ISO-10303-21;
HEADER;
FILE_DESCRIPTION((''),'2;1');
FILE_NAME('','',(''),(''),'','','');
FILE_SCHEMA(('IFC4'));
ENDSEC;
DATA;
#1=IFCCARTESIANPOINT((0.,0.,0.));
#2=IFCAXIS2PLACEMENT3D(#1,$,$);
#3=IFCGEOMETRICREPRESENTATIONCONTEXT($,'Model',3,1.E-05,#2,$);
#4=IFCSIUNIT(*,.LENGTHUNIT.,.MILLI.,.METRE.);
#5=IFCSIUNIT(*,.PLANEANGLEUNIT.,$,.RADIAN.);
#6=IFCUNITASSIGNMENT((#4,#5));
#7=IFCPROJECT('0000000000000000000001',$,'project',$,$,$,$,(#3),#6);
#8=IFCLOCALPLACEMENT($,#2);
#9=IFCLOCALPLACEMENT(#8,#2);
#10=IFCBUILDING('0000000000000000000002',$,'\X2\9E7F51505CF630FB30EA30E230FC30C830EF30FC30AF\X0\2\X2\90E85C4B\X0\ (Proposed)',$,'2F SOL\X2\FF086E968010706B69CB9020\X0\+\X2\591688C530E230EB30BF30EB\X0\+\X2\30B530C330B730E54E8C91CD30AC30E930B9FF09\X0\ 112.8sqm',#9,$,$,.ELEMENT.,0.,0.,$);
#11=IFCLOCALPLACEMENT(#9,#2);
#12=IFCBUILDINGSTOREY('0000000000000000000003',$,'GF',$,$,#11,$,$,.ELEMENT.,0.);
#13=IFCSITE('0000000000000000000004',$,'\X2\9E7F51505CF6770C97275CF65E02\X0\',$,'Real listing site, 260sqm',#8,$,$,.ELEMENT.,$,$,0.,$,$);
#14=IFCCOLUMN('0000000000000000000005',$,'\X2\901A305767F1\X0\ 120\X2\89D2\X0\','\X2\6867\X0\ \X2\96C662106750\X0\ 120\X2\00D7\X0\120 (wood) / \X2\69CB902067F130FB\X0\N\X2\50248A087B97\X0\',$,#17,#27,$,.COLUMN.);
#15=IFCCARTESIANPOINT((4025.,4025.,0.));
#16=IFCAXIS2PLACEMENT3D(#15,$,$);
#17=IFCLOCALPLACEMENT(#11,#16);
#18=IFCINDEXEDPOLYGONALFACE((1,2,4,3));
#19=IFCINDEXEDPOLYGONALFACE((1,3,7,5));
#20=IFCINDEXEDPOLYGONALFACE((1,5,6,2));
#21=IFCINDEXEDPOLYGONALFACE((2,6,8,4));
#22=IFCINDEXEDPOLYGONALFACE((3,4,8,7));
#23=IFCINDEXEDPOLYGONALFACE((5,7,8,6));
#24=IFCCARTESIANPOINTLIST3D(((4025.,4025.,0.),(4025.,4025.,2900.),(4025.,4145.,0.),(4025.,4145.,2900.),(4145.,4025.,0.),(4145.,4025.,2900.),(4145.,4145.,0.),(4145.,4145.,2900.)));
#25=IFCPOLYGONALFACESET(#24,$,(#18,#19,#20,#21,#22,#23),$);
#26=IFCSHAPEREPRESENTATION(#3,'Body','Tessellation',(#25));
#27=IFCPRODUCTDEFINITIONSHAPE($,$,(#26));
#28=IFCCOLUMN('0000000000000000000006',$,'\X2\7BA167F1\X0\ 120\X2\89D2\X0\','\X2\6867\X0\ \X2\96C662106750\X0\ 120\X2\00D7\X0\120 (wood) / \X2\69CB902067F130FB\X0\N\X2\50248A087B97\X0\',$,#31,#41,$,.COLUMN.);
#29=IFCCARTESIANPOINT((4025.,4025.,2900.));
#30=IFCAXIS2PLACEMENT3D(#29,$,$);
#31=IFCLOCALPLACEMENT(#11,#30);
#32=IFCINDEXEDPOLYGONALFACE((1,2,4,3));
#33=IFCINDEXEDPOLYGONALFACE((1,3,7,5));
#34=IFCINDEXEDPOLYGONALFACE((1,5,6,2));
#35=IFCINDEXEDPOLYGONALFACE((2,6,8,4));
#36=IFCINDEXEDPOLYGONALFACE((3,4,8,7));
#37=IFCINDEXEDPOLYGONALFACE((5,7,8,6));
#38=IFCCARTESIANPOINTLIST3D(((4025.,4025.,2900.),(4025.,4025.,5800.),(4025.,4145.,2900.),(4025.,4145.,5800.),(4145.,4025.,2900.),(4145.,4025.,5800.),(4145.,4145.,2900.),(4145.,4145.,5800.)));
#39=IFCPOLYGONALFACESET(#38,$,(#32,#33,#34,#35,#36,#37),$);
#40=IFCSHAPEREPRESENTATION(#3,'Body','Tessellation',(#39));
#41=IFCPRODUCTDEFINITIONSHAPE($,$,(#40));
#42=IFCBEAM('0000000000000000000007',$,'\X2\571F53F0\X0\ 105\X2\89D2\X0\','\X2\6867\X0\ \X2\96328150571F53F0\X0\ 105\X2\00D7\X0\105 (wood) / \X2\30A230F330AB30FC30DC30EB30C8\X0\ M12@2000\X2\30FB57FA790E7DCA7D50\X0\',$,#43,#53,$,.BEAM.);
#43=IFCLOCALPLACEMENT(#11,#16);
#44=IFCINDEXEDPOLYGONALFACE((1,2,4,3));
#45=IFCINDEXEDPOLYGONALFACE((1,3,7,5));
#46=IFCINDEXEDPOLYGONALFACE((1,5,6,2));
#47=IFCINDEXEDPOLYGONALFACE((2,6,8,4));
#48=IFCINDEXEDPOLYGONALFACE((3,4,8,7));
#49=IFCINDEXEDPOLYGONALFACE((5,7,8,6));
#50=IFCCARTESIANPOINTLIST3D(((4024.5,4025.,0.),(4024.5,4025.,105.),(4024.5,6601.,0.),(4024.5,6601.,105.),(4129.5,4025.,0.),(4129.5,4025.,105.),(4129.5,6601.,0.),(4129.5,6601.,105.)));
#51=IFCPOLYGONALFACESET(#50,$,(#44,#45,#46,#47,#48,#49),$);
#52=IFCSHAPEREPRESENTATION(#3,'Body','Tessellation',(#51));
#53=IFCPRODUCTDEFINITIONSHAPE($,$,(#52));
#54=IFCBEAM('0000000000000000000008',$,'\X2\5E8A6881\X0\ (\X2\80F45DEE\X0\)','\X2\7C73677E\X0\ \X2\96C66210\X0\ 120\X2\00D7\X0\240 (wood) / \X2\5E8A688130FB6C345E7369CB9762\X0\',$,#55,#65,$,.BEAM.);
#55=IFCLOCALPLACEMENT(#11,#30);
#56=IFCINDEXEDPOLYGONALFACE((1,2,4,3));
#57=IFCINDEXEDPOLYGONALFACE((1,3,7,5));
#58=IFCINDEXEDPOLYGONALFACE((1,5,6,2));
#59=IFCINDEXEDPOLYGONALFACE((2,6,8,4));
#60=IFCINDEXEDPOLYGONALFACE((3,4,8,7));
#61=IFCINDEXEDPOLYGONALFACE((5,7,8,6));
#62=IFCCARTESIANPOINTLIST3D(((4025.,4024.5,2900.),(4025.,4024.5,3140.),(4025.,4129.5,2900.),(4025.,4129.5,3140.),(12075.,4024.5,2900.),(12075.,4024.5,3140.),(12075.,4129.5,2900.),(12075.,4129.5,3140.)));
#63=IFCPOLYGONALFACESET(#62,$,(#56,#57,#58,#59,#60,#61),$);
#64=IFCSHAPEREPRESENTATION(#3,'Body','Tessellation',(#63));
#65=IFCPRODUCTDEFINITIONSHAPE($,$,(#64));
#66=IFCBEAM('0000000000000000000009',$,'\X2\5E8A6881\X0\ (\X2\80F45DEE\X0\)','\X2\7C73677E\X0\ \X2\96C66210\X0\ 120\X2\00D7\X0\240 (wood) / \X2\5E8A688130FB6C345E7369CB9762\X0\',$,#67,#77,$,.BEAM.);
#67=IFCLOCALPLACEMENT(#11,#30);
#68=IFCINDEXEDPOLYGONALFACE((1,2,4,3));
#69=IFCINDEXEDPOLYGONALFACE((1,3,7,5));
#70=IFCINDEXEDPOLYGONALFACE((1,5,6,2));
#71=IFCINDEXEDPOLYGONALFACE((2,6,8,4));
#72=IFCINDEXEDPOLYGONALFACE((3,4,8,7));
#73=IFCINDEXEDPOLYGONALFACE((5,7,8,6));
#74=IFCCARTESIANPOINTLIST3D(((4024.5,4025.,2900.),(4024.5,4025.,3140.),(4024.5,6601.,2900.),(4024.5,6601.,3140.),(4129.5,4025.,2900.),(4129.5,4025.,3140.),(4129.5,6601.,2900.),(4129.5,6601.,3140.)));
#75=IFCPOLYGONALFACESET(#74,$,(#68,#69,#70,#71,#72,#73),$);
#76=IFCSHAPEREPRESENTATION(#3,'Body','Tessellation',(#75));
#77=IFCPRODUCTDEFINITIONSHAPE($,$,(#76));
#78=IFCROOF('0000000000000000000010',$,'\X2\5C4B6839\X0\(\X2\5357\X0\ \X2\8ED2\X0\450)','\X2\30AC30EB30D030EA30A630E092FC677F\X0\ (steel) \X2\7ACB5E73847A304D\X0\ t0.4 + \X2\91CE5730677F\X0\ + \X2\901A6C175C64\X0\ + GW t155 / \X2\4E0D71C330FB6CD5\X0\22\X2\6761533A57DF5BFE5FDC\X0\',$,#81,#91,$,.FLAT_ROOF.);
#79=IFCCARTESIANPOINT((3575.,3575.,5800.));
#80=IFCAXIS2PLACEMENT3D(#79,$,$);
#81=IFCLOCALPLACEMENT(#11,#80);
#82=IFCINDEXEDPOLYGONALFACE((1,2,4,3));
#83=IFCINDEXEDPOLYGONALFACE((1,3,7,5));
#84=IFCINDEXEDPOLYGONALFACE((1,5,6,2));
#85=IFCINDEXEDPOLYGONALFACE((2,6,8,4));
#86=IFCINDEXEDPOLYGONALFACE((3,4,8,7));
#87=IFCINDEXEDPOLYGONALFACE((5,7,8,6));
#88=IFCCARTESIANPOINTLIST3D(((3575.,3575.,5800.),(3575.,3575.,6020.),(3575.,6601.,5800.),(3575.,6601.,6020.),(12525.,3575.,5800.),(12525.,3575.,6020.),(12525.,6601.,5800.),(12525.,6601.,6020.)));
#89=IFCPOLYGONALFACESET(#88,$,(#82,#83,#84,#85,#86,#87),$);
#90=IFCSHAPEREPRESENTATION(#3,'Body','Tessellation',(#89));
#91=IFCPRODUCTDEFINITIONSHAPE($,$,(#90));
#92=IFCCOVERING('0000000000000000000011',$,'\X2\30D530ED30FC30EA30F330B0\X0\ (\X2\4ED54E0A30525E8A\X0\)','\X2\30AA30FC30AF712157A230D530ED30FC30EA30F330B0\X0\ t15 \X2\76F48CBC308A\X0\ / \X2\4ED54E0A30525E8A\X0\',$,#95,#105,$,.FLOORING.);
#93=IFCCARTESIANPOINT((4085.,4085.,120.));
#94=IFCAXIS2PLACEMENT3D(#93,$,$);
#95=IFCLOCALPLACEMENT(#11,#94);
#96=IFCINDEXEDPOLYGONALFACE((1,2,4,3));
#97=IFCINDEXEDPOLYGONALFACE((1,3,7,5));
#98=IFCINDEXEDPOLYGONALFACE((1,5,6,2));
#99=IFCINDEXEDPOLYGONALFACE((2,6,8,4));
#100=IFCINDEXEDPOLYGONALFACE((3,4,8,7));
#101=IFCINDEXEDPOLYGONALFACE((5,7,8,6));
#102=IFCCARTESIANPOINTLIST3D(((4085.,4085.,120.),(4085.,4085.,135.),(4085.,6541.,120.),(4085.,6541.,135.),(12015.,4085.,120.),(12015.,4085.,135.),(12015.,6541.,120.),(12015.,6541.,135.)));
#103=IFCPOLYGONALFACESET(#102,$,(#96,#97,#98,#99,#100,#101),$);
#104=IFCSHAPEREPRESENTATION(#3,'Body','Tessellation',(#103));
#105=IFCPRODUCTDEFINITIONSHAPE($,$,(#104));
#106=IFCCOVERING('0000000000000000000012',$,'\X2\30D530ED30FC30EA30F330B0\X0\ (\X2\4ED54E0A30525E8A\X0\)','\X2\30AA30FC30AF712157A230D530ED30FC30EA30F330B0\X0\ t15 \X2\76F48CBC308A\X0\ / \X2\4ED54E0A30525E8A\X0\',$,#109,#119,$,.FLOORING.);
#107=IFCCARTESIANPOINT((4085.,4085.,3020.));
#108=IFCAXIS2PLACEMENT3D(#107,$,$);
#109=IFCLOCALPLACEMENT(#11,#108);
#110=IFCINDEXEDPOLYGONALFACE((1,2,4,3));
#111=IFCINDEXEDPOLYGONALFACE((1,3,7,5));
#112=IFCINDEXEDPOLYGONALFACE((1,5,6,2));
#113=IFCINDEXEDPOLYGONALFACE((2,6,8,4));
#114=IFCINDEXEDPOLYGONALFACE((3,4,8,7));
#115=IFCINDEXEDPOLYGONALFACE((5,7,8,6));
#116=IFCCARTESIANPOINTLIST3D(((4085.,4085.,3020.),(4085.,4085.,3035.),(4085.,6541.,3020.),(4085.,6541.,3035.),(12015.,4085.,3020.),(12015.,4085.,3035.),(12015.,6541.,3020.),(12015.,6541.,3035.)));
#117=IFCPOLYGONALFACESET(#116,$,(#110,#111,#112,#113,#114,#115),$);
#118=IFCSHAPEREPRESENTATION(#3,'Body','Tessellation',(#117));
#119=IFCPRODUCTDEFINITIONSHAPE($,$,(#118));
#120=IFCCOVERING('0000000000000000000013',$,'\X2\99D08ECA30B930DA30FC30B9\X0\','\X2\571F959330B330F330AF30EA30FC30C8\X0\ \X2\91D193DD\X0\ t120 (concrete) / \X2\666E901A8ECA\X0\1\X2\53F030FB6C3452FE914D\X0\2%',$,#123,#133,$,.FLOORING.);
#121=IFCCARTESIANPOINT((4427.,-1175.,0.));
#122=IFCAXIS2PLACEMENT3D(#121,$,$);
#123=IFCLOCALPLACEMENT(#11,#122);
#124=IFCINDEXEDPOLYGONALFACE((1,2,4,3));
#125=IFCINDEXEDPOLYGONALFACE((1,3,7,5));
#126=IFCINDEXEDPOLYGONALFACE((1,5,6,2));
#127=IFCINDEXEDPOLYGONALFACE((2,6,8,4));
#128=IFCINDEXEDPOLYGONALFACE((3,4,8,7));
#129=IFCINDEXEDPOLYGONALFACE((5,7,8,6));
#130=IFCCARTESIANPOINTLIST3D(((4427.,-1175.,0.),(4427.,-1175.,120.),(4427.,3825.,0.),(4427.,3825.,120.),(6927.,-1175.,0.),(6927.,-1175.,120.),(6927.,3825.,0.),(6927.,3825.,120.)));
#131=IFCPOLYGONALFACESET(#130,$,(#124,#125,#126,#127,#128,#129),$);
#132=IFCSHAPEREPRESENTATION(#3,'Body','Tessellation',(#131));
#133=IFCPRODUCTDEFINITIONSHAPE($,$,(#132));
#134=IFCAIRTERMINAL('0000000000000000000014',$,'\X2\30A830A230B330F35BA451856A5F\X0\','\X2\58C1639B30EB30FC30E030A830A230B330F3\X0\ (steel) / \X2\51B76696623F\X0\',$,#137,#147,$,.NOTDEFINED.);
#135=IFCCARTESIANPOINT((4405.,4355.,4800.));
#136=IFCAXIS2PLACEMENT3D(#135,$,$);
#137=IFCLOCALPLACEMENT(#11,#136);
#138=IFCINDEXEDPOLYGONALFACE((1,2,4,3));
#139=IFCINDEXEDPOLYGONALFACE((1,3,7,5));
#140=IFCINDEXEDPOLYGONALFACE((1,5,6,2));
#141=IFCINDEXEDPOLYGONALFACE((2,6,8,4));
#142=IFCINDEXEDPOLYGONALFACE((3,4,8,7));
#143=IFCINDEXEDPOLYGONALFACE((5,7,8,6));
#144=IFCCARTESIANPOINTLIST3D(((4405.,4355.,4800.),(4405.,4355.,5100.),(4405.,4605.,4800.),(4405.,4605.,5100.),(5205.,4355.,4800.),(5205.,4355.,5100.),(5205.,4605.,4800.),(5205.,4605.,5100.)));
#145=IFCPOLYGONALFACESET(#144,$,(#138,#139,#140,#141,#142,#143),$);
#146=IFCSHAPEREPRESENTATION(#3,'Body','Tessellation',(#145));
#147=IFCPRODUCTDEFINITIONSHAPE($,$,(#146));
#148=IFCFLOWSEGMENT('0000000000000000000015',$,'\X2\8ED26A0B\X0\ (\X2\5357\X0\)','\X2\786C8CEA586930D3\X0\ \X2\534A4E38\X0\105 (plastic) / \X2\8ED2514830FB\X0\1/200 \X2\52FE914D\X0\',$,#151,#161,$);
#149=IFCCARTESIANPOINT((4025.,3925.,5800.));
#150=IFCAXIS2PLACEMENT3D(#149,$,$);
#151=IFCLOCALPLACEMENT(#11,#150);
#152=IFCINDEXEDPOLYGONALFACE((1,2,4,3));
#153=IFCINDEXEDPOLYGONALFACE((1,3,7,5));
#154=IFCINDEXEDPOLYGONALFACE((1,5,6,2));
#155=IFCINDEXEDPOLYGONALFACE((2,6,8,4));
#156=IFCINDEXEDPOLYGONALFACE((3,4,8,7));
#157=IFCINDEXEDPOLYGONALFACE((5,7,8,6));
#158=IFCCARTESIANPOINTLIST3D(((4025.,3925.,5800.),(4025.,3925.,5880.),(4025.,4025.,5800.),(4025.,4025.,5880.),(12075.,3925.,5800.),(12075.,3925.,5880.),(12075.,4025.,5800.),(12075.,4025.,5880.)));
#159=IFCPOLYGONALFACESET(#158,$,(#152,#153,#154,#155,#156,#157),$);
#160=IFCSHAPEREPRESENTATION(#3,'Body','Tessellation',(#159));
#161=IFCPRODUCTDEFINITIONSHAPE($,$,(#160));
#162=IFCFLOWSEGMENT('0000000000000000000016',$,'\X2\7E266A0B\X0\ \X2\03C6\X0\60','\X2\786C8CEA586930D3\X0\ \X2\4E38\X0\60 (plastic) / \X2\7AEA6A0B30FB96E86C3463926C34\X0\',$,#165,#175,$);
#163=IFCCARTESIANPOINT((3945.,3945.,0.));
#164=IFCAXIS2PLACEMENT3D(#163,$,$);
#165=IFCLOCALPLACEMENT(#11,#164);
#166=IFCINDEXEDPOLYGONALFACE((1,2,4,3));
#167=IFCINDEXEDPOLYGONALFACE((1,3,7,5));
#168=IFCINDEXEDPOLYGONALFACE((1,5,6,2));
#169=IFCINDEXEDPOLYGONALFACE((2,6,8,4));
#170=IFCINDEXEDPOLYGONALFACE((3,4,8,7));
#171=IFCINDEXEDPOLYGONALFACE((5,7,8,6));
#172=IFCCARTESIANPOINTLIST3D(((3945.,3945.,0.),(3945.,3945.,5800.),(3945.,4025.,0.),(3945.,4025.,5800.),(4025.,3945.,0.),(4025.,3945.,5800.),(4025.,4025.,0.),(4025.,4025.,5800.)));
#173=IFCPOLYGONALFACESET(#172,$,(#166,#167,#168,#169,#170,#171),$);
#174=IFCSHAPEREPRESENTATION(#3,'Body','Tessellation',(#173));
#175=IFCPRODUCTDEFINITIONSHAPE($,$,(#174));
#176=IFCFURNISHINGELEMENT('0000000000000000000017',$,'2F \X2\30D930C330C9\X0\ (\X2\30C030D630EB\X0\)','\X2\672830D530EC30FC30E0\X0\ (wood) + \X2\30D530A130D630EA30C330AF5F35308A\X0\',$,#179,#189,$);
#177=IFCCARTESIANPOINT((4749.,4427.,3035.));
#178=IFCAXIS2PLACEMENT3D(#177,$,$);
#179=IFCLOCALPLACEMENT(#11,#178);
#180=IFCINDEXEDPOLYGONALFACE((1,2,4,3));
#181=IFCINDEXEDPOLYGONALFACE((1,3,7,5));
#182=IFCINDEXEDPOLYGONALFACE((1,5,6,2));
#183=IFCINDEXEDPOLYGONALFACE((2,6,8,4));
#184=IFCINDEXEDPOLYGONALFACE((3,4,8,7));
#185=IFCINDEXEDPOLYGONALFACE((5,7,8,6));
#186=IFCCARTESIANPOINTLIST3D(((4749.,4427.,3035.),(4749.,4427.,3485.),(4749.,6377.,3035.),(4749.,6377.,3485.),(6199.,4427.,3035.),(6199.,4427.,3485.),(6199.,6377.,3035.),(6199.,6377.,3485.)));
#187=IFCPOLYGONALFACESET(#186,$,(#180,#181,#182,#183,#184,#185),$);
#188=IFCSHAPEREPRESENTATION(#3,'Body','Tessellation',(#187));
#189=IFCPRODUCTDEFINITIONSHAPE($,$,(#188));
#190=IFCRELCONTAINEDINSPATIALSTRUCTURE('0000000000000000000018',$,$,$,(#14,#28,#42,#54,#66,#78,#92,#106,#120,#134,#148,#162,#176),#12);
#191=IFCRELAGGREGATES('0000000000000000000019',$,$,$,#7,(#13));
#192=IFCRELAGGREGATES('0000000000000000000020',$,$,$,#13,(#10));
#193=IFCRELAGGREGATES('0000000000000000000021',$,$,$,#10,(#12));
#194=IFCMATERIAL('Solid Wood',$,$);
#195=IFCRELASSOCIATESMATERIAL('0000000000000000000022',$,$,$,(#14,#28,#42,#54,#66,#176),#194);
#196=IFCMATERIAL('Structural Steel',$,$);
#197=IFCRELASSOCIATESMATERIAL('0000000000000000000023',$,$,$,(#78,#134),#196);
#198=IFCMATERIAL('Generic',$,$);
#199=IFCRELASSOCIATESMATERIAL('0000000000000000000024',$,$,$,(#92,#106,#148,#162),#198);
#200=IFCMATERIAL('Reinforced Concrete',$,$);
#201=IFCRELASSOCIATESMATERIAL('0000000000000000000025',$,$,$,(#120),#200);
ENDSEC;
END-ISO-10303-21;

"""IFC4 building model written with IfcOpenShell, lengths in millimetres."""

from ifc_helpers import new_model, si_unit, frame, frame_2d, origin, place, context, project, spatial, rectangle, extrude, material, element, save


model = new_model("IFC4")

# Units and contexts
model_context = context("Model", 3, precision=1e-05, world=origin())
ifc_project = project(units=[si_unit("LENGTHUNIT", "METRE", prefix="MILLI"), si_unit("PLANEANGLEUNIT", "RADIAN")], contexts=[model_context])

# Site, building, storey
site_placement = place(None, origin())
site = spatial("IfcSite", under=ifc_project, at=site_placement, Name="鹿児島県霧島市", ObjectType="Real listing site, 260sqm", CompositionType="ELEMENT", RefElevation=0.0)
building_placement = place(site_placement, origin())
building = spatial("IfcBuilding", under=site, at=building_placement, Name="鹿児島・リモートワーク2部屋 (Proposed)", ObjectType="2F SOL（準耐火構造+外装モルタル+サッシュ二重ガラス） 112.8sqm", CompositionType="ELEMENT", ElevationOfRefHeight=0.0, ElevationOfTerrain=0.0)
storey_placement = place(building_placement, origin())
storey = spatial("IfcBuildingStorey", under=building, at=storey_placement, Name="GF", CompositionType="ELEMENT", Elevation=0.0)

# Columns
ifc_material_1 = material(Name="Solid Wood")
column_1_placement = place(storey_placement, frame((4025.0, 4025.0, 0.0)))
element("IfcColumn", 1, at=column_1_placement, inside=storey, material=ifc_material_1, Name="通し柱 120角", Description="桧 集成材 120×120 (wood) / 構造柱・N値計算", PredefinedType="COLUMN", context=model_context, shape_type="SweptSolid", body=[
    extrude(rectangle(XDim=120.0, YDim=120.0, at=frame_2d((60.0, 60.0))), frame((4025.0, 4025.0, 0.0)), (0.0, 0.0, 1.0), 2900.0),
])
column_2_placement = place(storey_placement, frame((4025.0, 4025.0, 2900.0)))
element("IfcColumn", 2, at=column_2_placement, inside=storey, material=ifc_material_1, Name="管柱 120角", Description="桧 集成材 120×120 (wood) / 構造柱・N値計算", PredefinedType="COLUMN", context=model_context, shape_type="SweptSolid", body=[
    extrude(rectangle(XDim=120.0, YDim=120.0, at=frame_2d((60.0, 60.0))), frame((4025.0, 4025.0, 2900.0)), (0.0, 0.0, 1.0), 2900.0),
])

# Beams
beam_1_placement = place(storey_placement, frame((4025.0, 4025.0, 0.0)))
element("IfcBeam", 3, at=beam_1_placement, inside=storey, material=ifc_material_1, Name="土台 105角", Description="桧 防腐土台 105×105 (wood) / アンカーボルト M12@2000・基礎緊結", PredefinedType="BEAM", context=model_context, shape_type="SweptSolid", body=[
    extrude(rectangle(XDim=105.0, YDim=2576.0, at=frame_2d((52.0, 1288.0))), frame((4025.0, 4025.0, 0.0)), (0.0, 0.0, 1.0), 105.0),
])
beam_2_placement = place(storey_placement, frame((4025.0, 4025.0, 2900.0)))
element("IfcBeam", 4, at=beam_2_placement, inside=storey, material=ifc_material_1, Name="床梁 (胴差)", Description="米松 集成 120×240 (wood) / 床梁・水平構面", PredefinedType="BEAM", context=model_context, shape_type="SweptSolid", body=[
    extrude(rectangle(XDim=8050.0, YDim=105.0, at=frame_2d((4025.0, 52.0))), frame((4025.0, 4025.0, 2900.0)), (0.0, 0.0, 1.0), 240.0),
])
beam_3_placement = place(storey_placement, frame((4025.0, 4025.0, 2900.0)))
element("IfcBeam", 5, at=beam_3_placement, inside=storey, material=ifc_material_1, Name="床梁 (胴差)", Description="米松 集成 120×240 (wood) / 床梁・水平構面", PredefinedType="BEAM", context=model_context, shape_type="SweptSolid", body=[
    extrude(rectangle(XDim=105.0, YDim=2576.0, at=frame_2d((52.0, 1288.0))), frame((4025.0, 4025.0, 2900.0)), (0.0, 0.0, 1.0), 240.0),
])

# Shared definitions
ifc_material_2 = material(Name="Reinforced Concrete")

# Roof
ifc_material_3 = material(Name="Structural Steel")
for number, where, name in (
    (6, (3575.0, 3575.0, 5800.0), "屋根(南 軒450)"),
):
    element("IfcRoof", number, at=place(storey_placement, frame(where)), inside=storey, material=ifc_material_3, Name=name, Description="ガルバリウム鋼板 (steel) 立平葺き t0.4 + 野地板 + 通気層 + GW t155 / 不燃・法22条区域対応", PredefinedType="FLAT_ROOF", context=model_context, shape_type="SweptSolid", body=[
        extrude(rectangle(XDim=8950.0, YDim=3026.0, at=frame_2d((4475.0, 1513.0))), frame((3575.0, 3575.0, 5800.0)), (0.0, 0.0, 1.0), 220.0),
    ])

# Coverings
ifc_material_4 = material(Name="Generic")
covering_1_placement = place(storey_placement, frame((4085.0, 4085.0, 120.0)))
element("IfcCovering", 7, at=covering_1_placement, inside=storey, material=ifc_material_4, Name="フローリング (仕上げ床)", Description="オーク無垢フローリング t15 直貼り / 仕上げ床", PredefinedType="FLOORING", context=model_context, shape_type="SweptSolid", body=[
    extrude(rectangle(XDim=7930.0, YDim=2456.0, at=frame_2d((3965.0, 1228.0))), frame((4085.0, 4085.0, 120.0)), (0.0, 0.0, 1.0), 15.0),
])
covering_2_placement = place(storey_placement, frame((4085.0, 4085.0, 3020.0)))
element("IfcCovering", 8, at=covering_2_placement, inside=storey, material=ifc_material_4, Name="フローリング (仕上げ床)", Description="オーク無垢フローリング t15 直貼り / 仕上げ床", PredefinedType="FLOORING", context=model_context, shape_type="SweptSolid", body=[
    extrude(rectangle(XDim=7930.0, YDim=2456.0, at=frame_2d((3965.0, 1228.0))), frame((4085.0, 4085.0, 3020.0)), (0.0, 0.0, 1.0), 15.0),
])
covering_3_placement = place(storey_placement, frame((4427.0, -1175.0, 0.0)))
element("IfcCovering", 9, at=covering_3_placement, inside=storey, material=ifc_material_2, Name="駐車スペース", Description="土間コンクリート 金鏝 t120 (concrete) / 普通車1台・水勾配2%", PredefinedType="FLOORING", context=model_context, shape_type="SweptSolid", body=[
    extrude(rectangle(XDim=2500.0, YDim=5000.0, at=frame_2d((1250.0, 2500.0))), frame((4427.0, -1175.0, 0.0)), (0.0, 0.0, 1.0), 120.0),
])

# Air terminal
air_terminal_placement = place(storey_placement, frame((4405.0, 4355.0, 4800.0)))
element("IfcAirTerminal", 10, at=air_terminal_placement, inside=storey, material=ifc_material_3, Name="エアコン室内機", Description="壁掛ルームエアコン (steel) / 冷暖房", PredefinedType="NOTDEFINED", context=model_context, shape_type="SweptSolid", body=[
    extrude(rectangle(XDim=800.0, YDim=250.0, at=frame_2d((400.0, 125.0))), frame((4405.0, 4355.0, 4800.0)), (0.0, 0.0, 1.0), 300.0),
])

# Flow segments
flow_segment_1_placement = place(storey_placement, frame((4025.0, 3925.0, 5800.0)))
element("IfcFlowSegment", 11, at=flow_segment_1_placement, inside=storey, material=ifc_material_4, Name="軒樋 (南)", Description="硬質塩ビ 半丸105 (plastic) / 軒先・1/200 勾配", context=model_context, shape_type="SweptSolid", body=[
    extrude(rectangle(XDim=8050.0, YDim=100.0, at=frame_2d((4025.0, 50.0))), frame((4025.0, 3925.0, 5800.0)), (0.0, 0.0, 1.0), 80.0),
])
flow_segment_2_placement = place(storey_placement, frame((3945.0, 3945.0, 0.0)))
element("IfcFlowSegment", 12, at=flow_segment_2_placement, inside=storey, material=ifc_material_4, Name="縦樋 φ60", Description="硬質塩ビ 丸60 (plastic) / 竪樋・雨水排水", context=model_context, shape_type="SweptSolid", body=[
    extrude(rectangle(XDim=80.0, YDim=80.0, at=frame_2d((40.0, 40.0))), frame((3945.0, 3945.0, 0.0)), (0.0, 0.0, 1.0), 5800.0),
])

# Furnishing element
furnishing_placement = place(storey_placement, frame((4749.0, 4427.0, 3035.0)))
element("IfcFurnishingElement", 13, at=furnishing_placement, inside=storey, material=ifc_material_1, Name="2F ベッド (ダブル)", Description="木フレーム (wood) + ファブリック張り", context=model_context, shape_type="SweptSolid", body=[
    extrude(rectangle(XDim=1450.0, YDim=1950.0, at=frame_2d((725.0, 975.0))), frame((4749.0, 4427.0, 3035.0)), (0.0, 0.0, 1.0), 450.0),
])

save(model, "model.ifc")
